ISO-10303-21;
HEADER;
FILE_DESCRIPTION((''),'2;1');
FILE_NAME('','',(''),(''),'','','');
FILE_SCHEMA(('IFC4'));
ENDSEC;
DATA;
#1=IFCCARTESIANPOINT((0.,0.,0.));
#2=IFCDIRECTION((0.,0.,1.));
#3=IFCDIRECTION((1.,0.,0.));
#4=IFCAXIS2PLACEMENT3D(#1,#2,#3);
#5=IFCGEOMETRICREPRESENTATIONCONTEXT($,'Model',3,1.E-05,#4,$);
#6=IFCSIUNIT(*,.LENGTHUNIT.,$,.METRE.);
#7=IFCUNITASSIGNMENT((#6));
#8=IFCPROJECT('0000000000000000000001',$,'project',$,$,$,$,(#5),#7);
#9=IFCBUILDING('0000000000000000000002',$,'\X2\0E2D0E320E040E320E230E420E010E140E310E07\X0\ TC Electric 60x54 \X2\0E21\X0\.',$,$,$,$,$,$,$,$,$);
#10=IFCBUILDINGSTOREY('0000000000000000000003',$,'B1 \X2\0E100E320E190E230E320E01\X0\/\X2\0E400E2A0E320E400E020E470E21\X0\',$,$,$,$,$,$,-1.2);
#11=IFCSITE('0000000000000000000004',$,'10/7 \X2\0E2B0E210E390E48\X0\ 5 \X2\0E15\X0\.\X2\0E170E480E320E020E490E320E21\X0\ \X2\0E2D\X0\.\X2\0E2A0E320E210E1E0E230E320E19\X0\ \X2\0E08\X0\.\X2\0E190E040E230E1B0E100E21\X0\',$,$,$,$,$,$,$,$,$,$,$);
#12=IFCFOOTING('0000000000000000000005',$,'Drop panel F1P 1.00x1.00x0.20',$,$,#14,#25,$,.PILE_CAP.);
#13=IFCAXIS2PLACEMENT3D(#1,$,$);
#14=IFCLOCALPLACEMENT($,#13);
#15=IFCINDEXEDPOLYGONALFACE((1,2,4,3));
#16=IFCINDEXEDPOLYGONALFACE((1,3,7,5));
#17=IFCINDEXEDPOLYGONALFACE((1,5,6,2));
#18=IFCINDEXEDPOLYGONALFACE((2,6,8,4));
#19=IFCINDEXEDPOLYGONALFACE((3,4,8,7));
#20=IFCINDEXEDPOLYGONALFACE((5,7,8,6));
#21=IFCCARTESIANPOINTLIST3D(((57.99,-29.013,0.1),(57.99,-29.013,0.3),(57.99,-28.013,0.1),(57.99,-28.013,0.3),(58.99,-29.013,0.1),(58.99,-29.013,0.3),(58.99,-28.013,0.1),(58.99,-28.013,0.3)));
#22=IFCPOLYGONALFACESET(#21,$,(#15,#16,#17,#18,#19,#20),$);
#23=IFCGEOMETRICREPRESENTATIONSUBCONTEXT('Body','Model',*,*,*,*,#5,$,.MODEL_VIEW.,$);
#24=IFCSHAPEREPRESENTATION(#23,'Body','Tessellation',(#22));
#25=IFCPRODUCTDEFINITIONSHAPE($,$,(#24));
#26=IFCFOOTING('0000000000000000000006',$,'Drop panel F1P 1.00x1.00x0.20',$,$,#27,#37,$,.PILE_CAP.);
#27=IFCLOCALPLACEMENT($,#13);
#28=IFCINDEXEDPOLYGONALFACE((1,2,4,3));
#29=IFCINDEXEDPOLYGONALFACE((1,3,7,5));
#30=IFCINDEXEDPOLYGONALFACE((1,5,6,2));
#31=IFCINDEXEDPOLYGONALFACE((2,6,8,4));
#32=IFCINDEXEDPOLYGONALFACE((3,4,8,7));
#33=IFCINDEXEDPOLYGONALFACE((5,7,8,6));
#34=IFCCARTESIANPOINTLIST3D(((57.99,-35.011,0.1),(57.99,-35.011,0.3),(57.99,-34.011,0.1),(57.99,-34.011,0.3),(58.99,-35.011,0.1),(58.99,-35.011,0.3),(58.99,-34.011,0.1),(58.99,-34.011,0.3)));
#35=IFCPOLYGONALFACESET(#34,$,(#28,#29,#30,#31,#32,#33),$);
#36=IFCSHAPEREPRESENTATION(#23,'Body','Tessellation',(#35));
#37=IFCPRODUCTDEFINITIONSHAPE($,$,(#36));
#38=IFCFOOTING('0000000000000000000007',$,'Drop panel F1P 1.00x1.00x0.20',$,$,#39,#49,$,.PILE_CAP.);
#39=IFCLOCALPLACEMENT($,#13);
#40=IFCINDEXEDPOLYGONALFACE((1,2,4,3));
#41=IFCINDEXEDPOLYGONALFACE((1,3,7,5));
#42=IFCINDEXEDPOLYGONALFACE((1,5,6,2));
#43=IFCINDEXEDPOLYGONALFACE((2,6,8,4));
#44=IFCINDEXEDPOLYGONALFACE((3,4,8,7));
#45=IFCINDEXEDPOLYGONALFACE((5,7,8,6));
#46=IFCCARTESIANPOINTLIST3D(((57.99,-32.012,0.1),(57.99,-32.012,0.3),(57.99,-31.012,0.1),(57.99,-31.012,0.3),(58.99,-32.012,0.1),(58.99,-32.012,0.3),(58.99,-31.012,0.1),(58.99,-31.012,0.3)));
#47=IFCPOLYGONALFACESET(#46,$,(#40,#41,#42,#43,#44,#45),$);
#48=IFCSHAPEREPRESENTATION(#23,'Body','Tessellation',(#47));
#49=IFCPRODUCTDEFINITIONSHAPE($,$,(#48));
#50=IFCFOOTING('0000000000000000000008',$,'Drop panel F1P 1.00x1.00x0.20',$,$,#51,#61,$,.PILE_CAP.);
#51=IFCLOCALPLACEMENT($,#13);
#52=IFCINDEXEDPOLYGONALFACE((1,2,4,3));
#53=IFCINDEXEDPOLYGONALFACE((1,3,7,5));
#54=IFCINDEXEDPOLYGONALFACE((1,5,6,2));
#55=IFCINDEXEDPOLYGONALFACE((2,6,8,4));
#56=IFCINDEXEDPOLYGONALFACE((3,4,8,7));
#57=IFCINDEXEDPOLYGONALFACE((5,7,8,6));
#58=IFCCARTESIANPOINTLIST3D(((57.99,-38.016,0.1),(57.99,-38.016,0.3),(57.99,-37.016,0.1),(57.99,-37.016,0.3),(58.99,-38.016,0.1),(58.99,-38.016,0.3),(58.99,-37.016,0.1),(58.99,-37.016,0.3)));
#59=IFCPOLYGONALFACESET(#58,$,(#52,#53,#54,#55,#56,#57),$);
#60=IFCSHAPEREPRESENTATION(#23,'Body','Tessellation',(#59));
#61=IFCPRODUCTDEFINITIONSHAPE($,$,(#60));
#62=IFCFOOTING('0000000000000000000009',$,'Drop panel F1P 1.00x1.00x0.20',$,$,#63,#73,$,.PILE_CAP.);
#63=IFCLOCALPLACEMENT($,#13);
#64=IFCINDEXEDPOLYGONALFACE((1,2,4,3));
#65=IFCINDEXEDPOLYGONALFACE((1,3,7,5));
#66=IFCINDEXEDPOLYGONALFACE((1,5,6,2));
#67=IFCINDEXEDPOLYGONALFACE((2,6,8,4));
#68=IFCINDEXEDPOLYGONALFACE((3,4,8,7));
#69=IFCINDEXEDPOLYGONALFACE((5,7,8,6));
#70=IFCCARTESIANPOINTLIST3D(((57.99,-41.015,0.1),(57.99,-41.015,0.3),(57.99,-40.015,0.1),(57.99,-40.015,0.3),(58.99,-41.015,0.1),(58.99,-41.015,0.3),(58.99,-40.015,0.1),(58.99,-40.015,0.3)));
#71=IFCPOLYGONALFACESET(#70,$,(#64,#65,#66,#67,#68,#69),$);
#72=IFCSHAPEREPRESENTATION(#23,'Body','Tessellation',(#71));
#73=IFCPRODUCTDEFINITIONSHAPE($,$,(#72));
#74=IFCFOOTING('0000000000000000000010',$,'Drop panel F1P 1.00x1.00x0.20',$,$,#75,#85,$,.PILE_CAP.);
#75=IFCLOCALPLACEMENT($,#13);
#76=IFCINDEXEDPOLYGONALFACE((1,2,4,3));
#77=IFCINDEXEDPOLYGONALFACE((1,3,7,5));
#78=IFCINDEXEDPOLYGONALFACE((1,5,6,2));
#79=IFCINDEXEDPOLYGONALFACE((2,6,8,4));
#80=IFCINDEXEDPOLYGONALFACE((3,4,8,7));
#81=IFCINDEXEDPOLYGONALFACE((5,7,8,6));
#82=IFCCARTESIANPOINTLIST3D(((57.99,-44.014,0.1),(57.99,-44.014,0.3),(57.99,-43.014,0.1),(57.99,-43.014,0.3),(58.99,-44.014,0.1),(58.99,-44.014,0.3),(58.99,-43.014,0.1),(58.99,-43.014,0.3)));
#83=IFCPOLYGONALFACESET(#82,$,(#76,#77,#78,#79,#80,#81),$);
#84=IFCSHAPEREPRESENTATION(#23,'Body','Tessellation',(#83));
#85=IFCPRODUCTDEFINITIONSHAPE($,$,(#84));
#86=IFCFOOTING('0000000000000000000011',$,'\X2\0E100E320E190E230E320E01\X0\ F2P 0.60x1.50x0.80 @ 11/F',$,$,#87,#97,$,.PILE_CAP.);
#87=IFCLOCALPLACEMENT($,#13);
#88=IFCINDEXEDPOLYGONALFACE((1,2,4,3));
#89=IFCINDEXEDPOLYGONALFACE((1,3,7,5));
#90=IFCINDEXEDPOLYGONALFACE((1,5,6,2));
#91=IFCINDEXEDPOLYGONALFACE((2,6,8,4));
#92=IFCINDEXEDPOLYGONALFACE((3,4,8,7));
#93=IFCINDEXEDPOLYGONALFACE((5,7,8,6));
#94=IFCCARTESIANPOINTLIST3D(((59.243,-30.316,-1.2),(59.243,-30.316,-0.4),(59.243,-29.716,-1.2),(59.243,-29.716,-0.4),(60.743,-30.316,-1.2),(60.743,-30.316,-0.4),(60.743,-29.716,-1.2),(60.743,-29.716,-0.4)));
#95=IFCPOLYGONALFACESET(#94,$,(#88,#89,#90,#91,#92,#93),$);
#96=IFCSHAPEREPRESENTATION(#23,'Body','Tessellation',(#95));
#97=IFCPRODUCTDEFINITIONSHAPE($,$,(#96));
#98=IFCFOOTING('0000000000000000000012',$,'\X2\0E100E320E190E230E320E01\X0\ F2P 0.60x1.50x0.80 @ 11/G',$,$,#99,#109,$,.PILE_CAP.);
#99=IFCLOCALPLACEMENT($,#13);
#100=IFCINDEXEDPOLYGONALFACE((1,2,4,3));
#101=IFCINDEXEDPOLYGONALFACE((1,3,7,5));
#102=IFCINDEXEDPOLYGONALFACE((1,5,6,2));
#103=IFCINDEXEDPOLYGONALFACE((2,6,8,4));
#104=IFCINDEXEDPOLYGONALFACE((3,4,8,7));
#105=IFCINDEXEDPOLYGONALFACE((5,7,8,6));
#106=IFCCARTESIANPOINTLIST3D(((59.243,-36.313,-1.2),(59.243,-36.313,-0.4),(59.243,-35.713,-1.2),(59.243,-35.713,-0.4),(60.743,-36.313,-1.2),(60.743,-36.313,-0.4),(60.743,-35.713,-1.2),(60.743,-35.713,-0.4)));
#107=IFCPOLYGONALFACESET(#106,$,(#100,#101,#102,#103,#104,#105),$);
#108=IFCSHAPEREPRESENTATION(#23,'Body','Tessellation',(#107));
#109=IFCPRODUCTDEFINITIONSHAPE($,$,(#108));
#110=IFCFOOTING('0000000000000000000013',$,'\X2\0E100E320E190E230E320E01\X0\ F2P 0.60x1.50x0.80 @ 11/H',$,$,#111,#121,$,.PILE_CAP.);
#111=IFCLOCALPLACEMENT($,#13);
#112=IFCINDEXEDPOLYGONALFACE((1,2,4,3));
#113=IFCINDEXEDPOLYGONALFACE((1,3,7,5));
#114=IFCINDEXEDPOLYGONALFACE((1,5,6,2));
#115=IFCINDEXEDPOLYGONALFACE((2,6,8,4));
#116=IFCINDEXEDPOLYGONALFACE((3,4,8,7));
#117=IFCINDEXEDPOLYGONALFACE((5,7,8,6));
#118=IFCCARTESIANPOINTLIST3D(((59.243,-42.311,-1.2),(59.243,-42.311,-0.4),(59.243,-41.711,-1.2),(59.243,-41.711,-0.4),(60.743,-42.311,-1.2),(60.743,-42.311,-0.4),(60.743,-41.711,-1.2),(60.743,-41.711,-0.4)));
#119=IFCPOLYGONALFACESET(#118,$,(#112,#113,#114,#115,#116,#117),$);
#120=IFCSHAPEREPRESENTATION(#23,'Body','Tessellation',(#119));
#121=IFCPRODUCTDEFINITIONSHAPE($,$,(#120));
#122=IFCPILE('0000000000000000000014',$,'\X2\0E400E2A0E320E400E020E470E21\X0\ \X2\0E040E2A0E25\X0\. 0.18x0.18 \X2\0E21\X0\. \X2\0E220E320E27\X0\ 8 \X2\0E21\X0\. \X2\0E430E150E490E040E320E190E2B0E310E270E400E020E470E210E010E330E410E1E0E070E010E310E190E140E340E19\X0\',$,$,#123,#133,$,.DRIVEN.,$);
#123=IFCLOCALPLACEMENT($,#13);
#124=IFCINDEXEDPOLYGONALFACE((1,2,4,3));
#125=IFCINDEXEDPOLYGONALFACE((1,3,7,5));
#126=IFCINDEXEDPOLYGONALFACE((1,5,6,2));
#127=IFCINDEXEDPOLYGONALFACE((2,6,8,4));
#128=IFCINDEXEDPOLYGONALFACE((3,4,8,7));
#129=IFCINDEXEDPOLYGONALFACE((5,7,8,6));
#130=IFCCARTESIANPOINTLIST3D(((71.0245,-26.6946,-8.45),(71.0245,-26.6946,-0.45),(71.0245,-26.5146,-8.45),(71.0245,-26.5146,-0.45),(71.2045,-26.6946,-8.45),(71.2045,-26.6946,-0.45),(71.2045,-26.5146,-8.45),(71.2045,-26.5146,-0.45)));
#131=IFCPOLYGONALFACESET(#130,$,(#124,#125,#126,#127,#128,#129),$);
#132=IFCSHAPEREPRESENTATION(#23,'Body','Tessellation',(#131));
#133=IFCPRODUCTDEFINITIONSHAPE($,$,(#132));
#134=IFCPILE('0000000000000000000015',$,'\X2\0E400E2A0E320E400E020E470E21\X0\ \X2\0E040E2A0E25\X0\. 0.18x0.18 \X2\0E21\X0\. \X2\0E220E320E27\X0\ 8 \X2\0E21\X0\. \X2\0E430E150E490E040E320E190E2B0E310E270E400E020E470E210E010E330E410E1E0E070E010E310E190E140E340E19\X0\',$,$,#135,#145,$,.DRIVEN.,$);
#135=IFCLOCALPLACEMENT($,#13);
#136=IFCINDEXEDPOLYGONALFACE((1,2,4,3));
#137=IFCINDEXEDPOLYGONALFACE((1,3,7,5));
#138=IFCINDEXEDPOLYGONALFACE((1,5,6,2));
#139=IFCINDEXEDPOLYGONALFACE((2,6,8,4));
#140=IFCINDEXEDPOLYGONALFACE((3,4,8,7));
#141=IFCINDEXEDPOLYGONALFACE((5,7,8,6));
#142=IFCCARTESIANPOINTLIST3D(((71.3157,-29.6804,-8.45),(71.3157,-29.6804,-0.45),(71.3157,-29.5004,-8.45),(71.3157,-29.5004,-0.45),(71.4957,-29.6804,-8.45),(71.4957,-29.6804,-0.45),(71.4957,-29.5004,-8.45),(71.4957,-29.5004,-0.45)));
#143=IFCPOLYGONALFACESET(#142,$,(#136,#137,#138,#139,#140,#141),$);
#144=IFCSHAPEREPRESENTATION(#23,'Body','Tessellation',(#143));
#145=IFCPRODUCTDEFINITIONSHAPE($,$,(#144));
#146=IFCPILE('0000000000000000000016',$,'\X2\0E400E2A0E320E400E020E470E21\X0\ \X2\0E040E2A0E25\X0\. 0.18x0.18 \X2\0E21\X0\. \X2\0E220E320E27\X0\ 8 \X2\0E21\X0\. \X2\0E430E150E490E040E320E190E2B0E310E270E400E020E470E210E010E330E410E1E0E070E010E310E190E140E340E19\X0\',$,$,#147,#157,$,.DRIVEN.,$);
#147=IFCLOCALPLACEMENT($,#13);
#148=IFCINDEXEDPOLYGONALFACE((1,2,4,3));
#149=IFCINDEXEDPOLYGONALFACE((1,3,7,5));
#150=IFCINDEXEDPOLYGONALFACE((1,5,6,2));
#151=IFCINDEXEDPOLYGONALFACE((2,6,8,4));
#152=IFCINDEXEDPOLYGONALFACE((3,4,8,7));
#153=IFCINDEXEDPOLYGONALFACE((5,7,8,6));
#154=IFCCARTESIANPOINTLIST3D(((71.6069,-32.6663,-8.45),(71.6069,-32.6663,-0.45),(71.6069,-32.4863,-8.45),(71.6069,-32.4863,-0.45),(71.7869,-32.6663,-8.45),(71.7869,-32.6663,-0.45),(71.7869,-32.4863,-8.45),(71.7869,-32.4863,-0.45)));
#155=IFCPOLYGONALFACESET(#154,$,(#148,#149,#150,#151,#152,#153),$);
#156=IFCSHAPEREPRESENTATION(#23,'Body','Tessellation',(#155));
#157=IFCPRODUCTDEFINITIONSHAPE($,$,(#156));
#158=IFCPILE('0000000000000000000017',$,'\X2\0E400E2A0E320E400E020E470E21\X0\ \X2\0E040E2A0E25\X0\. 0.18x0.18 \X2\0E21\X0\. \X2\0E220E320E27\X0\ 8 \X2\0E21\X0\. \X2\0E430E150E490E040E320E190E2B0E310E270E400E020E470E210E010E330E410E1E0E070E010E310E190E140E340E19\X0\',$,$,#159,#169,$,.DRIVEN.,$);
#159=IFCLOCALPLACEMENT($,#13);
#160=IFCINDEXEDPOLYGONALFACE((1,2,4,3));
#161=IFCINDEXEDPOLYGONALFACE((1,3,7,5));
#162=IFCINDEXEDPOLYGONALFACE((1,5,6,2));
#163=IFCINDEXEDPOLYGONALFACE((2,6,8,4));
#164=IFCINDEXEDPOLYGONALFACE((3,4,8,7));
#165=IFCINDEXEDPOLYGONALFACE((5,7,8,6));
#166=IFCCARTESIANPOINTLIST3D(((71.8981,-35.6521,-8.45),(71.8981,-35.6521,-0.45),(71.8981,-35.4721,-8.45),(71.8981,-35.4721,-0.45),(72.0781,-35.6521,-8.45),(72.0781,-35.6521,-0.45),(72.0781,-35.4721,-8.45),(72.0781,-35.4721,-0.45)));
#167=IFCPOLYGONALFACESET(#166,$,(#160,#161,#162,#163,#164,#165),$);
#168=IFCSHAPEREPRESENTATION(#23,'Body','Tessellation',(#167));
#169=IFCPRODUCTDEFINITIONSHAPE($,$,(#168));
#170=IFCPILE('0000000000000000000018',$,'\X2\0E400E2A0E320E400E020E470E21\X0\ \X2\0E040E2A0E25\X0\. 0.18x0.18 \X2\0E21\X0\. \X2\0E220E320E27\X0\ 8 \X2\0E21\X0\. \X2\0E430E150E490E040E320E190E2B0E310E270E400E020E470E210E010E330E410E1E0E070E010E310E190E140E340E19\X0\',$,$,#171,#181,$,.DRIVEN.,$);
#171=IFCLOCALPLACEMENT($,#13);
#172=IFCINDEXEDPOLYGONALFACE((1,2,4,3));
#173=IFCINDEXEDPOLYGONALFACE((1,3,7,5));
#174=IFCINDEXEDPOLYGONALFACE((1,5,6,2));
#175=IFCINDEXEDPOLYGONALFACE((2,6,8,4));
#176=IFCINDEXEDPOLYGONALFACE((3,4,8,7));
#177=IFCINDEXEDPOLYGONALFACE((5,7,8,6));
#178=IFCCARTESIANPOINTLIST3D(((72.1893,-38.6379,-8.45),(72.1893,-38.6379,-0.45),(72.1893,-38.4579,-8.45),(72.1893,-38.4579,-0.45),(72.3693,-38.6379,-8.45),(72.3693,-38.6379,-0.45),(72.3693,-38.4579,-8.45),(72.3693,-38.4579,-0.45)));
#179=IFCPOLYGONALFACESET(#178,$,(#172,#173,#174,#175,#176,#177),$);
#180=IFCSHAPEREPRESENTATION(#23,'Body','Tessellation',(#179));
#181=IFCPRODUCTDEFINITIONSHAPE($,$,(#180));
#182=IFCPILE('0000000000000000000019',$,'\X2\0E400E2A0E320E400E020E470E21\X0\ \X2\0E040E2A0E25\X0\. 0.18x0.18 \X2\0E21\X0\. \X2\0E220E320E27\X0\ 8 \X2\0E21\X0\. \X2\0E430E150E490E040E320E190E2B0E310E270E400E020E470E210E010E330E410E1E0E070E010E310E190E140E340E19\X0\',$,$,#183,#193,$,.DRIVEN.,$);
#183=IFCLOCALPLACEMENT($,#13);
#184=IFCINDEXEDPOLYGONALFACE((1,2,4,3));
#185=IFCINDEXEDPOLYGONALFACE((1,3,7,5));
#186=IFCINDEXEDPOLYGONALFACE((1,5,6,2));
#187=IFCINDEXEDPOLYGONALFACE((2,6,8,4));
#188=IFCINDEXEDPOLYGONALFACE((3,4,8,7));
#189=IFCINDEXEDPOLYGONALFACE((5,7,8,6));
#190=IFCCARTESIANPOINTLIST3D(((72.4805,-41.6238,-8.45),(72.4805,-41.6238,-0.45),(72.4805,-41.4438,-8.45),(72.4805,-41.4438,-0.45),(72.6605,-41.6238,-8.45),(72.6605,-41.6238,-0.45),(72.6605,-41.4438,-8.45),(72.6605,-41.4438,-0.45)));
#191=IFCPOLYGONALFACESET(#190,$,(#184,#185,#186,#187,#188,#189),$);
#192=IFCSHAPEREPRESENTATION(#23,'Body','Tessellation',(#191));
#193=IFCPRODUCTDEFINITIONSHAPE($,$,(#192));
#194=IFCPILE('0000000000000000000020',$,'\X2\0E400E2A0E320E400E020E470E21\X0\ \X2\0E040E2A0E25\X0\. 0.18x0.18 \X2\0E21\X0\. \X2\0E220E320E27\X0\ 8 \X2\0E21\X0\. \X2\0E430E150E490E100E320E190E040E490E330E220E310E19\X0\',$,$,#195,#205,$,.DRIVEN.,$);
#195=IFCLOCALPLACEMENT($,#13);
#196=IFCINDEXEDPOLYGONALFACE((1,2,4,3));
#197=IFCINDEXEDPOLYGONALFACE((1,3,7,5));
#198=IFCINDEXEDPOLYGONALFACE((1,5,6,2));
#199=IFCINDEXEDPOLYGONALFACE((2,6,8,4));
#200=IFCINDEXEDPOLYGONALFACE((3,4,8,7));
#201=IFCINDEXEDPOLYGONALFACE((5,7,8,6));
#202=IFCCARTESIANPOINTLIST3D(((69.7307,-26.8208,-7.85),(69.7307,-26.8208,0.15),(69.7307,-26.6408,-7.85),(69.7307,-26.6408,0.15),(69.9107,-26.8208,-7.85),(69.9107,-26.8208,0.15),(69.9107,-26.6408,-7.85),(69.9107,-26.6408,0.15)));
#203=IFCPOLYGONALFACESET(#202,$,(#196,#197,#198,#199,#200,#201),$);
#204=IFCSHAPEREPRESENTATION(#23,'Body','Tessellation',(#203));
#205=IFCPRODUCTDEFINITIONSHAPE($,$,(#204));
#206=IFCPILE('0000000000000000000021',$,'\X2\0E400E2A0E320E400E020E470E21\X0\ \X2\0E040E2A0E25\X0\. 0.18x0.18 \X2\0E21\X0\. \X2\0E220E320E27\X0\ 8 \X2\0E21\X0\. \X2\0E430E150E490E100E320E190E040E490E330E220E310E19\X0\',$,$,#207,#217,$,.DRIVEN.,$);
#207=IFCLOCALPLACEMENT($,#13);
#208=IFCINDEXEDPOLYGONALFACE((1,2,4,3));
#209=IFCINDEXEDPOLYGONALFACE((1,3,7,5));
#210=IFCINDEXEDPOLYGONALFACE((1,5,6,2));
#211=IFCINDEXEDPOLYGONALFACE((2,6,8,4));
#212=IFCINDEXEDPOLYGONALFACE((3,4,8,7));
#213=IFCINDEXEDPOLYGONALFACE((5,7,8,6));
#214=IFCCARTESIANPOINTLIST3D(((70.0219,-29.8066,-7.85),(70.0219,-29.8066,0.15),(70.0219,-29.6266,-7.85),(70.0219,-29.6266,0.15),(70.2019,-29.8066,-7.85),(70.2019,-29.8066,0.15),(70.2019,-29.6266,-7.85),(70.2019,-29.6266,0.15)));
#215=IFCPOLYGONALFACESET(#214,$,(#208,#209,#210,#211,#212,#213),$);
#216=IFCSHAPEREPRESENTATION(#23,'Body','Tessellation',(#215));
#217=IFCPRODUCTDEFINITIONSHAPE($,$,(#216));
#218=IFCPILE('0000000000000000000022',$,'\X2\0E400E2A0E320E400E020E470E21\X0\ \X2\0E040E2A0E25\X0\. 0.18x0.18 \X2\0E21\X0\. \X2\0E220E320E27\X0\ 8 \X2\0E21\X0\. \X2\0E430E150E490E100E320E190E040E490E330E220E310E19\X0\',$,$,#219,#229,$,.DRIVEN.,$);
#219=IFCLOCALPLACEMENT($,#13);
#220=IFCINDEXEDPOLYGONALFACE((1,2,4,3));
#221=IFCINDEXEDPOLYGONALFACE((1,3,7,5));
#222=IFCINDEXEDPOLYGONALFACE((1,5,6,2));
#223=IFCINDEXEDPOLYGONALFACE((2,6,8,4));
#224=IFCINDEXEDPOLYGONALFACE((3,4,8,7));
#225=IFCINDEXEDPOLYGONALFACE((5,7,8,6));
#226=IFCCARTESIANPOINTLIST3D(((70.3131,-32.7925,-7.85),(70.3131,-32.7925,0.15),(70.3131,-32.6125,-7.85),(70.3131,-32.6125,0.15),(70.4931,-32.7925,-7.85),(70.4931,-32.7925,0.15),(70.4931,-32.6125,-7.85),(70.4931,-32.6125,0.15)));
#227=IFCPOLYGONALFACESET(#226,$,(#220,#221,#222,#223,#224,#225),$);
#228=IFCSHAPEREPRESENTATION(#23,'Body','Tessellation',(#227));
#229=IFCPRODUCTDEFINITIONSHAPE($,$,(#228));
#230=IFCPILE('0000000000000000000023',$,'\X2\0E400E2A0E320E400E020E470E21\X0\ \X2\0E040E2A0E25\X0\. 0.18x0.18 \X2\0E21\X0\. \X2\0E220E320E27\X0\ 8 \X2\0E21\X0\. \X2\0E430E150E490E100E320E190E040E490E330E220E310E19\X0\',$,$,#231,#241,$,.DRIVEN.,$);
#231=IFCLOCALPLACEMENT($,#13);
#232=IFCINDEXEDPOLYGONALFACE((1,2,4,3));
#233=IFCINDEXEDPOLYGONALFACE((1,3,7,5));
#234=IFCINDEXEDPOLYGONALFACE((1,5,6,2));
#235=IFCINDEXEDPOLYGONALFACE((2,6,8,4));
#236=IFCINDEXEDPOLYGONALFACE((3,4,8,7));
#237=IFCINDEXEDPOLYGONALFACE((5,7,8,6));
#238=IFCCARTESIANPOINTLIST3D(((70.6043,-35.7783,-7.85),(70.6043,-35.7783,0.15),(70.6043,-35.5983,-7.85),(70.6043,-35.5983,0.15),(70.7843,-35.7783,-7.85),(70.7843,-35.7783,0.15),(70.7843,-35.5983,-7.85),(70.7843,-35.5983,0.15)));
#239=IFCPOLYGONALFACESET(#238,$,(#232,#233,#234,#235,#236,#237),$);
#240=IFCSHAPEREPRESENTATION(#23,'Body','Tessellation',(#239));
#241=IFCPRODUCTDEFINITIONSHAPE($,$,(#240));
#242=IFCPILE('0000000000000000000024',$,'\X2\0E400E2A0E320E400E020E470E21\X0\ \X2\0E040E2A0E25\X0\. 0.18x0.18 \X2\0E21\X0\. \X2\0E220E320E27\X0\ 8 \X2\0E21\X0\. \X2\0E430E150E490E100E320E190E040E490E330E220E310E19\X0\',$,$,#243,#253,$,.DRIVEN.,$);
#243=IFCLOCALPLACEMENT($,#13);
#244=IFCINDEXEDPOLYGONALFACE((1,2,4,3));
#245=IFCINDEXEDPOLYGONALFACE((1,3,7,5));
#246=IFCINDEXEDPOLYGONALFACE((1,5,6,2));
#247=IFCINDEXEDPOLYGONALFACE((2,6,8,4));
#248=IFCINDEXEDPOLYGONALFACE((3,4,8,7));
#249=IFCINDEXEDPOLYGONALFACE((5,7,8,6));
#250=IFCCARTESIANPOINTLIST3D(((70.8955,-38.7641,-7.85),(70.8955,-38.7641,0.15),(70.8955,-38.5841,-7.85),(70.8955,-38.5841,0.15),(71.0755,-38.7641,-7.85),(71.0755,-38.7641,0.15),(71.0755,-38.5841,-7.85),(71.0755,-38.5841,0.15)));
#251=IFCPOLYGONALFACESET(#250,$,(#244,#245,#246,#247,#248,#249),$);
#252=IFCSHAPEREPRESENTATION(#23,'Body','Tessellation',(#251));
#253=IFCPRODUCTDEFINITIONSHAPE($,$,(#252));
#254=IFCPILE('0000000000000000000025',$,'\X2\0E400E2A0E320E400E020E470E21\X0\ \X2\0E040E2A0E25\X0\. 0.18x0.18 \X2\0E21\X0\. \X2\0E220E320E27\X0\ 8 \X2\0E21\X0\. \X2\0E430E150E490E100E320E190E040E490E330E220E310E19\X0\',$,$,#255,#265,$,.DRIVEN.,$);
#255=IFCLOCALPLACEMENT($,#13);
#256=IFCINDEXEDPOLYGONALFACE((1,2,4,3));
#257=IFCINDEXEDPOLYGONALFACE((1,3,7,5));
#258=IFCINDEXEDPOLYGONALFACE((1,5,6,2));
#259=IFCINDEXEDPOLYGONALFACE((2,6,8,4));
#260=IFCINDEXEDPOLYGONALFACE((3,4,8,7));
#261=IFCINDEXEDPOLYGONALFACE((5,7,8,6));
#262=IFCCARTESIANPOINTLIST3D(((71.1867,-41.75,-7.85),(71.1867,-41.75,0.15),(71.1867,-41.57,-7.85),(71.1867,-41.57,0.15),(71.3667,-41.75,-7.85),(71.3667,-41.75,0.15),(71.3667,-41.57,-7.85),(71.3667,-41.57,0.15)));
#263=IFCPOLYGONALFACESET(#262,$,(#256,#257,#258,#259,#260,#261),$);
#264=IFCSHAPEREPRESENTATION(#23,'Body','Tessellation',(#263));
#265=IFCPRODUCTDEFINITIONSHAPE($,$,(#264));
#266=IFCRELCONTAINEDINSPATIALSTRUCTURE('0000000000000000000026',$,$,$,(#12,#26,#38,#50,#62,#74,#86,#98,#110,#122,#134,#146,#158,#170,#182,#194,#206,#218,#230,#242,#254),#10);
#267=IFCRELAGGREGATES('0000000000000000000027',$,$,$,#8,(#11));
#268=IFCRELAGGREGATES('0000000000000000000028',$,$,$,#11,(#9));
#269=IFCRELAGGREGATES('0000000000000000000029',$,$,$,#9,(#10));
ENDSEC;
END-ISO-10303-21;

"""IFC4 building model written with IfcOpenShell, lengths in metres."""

from ifc_helpers import new_model, si_unit, frame, origin, origin_with_axes, origin_2d, place, context, subcontext, project, spatial, rectangle, extrude, element, save


model = new_model("IFC4")

# Units and contexts
model_context = context("Model", 3, precision=1e-05, world=origin_with_axes())
body_context = subcontext(model_context, "Body", "Model", "MODEL_VIEW")
ifc_project = project(units=[si_unit("LENGTHUNIT", "METRE")], contexts=[model_context])

# Site, building, storey
site = spatial("IfcSite", under=ifc_project, Name="10/7 หมู่ 5 ต.ท่าข้าม อ.สามพราน จ.นครปฐม")
building = spatial("IfcBuilding", under=site, Name="อาคารโกดัง TC Electric 60x54 ม.")
storey = spatial("IfcBuildingStorey", under=building, Name="B1 ฐานราก/เสาเข็ม", Elevation=-1.2)

# Footings
for number, where, z_axis, x_axis, name in (
    (1, (58.49, -28.513, 0.1), (0.0, 0.0, 1.0), (1.0, 0.0, 0.0), "Drop panel F1P 1.00x1.00x0.20"),
    (2, (58.49, -34.511, 0.1), (0.0, 0.0, 1.0), (1.0, 0.0, 0.0), "Drop panel F1P 1.00x1.00x0.20"),
    (3, (58.49, -31.512, 0.1), (0.0, 0.0, 1.0), (1.0, 0.0, 0.0), "Drop panel F1P 1.00x1.00x0.20"),
    (4, (58.49, -37.516, 0.1), (0.0, 0.0, 1.0), (1.0, 0.0, 0.0), "Drop panel F1P 1.00x1.00x0.20"),
    (5, (58.49, -40.515, 0.1), (0.0, 0.0, 1.0), (1.0, 0.0, 0.0), "Drop panel F1P 1.00x1.00x0.20"),
    (6, (58.49, -43.514, 0.1), (0.0, 0.0, 1.0), (1.0, 0.0, 0.0), "Drop panel F1P 1.00x1.00x0.20"),
):
    element("IfcFooting", number, at=place(None, frame(where, z_axis=z_axis, x_axis=x_axis)), inside=storey, Name=name, PredefinedType="PILE_CAP", context=body_context, shape_type="SweptSolid", body=[
        extrude(rectangle(XDim=1.0, YDim=1.0, at=origin_2d()), origin(), (0.0, 0.0, 1.0), 0.2),
    ])
for number, where, z_axis, x_axis, name in (
    (7, (59.993, -30.016, -1.2), (0.0, 0.0, 1.0), (1.0, 0.0, 0.0), "ฐานราก F2P 0.60x1.50x0.80 @ 11/F"),
    (8, (59.993, -36.013, -1.2), (0.0, 0.0, 1.0), (1.0, 0.0, 0.0), "ฐานราก F2P 0.60x1.50x0.80 @ 11/G"),
    (9, (59.993, -42.011, -1.2), (0.0, 0.0, 1.0), (1.0, 0.0, 0.0), "ฐานราก F2P 0.60x1.50x0.80 @ 11/H"),
):
    element("IfcFooting", number, at=place(None, frame(where, z_axis=z_axis, x_axis=x_axis)), inside=storey, Name=name, PredefinedType="PILE_CAP", context=body_context, shape_type="SweptSolid", body=[
        extrude(rectangle(XDim=1.5, YDim=0.6, at=origin_2d()), origin(), (0.0, 0.0, 1.0), 0.8),
    ])

# Piles
for number, where, z_axis, x_axis, name in (
    (10, (71.1145, -26.6046, -8.45), (0.0, 0.0, 1.0), (1.0, 0.0, 0.0), "เสาเข็ม คสล. 0.18x0.18 ม. ยาว 8 ม. ใต้คานหัวเข็มกำแพงกันดิน"),
    (11, (71.4057, -29.5904, -8.45), (0.0, 0.0, 1.0), (1.0, 0.0, 0.0), "เสาเข็ม คสล. 0.18x0.18 ม. ยาว 8 ม. ใต้คานหัวเข็มกำแพงกันดิน"),
    (12, (71.6969, -32.5763, -8.45), (0.0, 0.0, 1.0), (1.0, 0.0, 0.0), "เสาเข็ม คสล. 0.18x0.18 ม. ยาว 8 ม. ใต้คานหัวเข็มกำแพงกันดิน"),
    (13, (71.9881, -35.5621, -8.45), (0.0, 0.0, 1.0), (1.0, 0.0, 0.0), "เสาเข็ม คสล. 0.18x0.18 ม. ยาว 8 ม. ใต้คานหัวเข็มกำแพงกันดิน"),
    (14, (72.2793, -38.5479, -8.45), (0.0, 0.0, 1.0), (1.0, 0.0, 0.0), "เสาเข็ม คสล. 0.18x0.18 ม. ยาว 8 ม. ใต้คานหัวเข็มกำแพงกันดิน"),
    (15, (72.5705, -41.5338, -8.45), (0.0, 0.0, 1.0), (1.0, 0.0, 0.0), "เสาเข็ม คสล. 0.18x0.18 ม. ยาว 8 ม. ใต้คานหัวเข็มกำแพงกันดิน"),
    (16, (69.8207, -26.7308, -7.85), (0.0, 0.0, 1.0), (1.0, 0.0, 0.0), "เสาเข็ม คสล. 0.18x0.18 ม. ยาว 8 ม. ใต้ฐานค้ำยัน"),
    (17, (70.1119, -29.7166, -7.85), (0.0, 0.0, 1.0), (1.0, 0.0, 0.0), "เสาเข็ม คสล. 0.18x0.18 ม. ยาว 8 ม. ใต้ฐานค้ำยัน"),
    (18, (70.4031, -32.7025, -7.85), (0.0, 0.0, 1.0), (1.0, 0.0, 0.0), "เสาเข็ม คสล. 0.18x0.18 ม. ยาว 8 ม. ใต้ฐานค้ำยัน"),
    (19, (70.6943, -35.6883, -7.85), (0.0, 0.0, 1.0), (1.0, 0.0, 0.0), "เสาเข็ม คสล. 0.18x0.18 ม. ยาว 8 ม. ใต้ฐานค้ำยัน"),
    (20, (70.9855, -38.6741, -7.85), (0.0, 0.0, 1.0), (1.0, 0.0, 0.0), "เสาเข็ม คสล. 0.18x0.18 ม. ยาว 8 ม. ใต้ฐานค้ำยัน"),
    (21, (71.2767, -41.66, -7.85), (0.0, 0.0, 1.0), (1.0, 0.0, 0.0), "เสาเข็ม คสล. 0.18x0.18 ม. ยาว 8 ม. ใต้ฐานค้ำยัน"),
):
    element("IfcPile", number, at=place(None, frame(where, z_axis=z_axis, x_axis=x_axis)), inside=storey, Name=name, PredefinedType="DRIVEN", context=body_context, shape_type="SweptSolid", body=[
        extrude(rectangle(XDim=0.18, YDim=0.18, at=origin_2d()), origin(), (0.0, 0.0, 1.0), 8.0),
    ])

save(model, "model.ifc")
